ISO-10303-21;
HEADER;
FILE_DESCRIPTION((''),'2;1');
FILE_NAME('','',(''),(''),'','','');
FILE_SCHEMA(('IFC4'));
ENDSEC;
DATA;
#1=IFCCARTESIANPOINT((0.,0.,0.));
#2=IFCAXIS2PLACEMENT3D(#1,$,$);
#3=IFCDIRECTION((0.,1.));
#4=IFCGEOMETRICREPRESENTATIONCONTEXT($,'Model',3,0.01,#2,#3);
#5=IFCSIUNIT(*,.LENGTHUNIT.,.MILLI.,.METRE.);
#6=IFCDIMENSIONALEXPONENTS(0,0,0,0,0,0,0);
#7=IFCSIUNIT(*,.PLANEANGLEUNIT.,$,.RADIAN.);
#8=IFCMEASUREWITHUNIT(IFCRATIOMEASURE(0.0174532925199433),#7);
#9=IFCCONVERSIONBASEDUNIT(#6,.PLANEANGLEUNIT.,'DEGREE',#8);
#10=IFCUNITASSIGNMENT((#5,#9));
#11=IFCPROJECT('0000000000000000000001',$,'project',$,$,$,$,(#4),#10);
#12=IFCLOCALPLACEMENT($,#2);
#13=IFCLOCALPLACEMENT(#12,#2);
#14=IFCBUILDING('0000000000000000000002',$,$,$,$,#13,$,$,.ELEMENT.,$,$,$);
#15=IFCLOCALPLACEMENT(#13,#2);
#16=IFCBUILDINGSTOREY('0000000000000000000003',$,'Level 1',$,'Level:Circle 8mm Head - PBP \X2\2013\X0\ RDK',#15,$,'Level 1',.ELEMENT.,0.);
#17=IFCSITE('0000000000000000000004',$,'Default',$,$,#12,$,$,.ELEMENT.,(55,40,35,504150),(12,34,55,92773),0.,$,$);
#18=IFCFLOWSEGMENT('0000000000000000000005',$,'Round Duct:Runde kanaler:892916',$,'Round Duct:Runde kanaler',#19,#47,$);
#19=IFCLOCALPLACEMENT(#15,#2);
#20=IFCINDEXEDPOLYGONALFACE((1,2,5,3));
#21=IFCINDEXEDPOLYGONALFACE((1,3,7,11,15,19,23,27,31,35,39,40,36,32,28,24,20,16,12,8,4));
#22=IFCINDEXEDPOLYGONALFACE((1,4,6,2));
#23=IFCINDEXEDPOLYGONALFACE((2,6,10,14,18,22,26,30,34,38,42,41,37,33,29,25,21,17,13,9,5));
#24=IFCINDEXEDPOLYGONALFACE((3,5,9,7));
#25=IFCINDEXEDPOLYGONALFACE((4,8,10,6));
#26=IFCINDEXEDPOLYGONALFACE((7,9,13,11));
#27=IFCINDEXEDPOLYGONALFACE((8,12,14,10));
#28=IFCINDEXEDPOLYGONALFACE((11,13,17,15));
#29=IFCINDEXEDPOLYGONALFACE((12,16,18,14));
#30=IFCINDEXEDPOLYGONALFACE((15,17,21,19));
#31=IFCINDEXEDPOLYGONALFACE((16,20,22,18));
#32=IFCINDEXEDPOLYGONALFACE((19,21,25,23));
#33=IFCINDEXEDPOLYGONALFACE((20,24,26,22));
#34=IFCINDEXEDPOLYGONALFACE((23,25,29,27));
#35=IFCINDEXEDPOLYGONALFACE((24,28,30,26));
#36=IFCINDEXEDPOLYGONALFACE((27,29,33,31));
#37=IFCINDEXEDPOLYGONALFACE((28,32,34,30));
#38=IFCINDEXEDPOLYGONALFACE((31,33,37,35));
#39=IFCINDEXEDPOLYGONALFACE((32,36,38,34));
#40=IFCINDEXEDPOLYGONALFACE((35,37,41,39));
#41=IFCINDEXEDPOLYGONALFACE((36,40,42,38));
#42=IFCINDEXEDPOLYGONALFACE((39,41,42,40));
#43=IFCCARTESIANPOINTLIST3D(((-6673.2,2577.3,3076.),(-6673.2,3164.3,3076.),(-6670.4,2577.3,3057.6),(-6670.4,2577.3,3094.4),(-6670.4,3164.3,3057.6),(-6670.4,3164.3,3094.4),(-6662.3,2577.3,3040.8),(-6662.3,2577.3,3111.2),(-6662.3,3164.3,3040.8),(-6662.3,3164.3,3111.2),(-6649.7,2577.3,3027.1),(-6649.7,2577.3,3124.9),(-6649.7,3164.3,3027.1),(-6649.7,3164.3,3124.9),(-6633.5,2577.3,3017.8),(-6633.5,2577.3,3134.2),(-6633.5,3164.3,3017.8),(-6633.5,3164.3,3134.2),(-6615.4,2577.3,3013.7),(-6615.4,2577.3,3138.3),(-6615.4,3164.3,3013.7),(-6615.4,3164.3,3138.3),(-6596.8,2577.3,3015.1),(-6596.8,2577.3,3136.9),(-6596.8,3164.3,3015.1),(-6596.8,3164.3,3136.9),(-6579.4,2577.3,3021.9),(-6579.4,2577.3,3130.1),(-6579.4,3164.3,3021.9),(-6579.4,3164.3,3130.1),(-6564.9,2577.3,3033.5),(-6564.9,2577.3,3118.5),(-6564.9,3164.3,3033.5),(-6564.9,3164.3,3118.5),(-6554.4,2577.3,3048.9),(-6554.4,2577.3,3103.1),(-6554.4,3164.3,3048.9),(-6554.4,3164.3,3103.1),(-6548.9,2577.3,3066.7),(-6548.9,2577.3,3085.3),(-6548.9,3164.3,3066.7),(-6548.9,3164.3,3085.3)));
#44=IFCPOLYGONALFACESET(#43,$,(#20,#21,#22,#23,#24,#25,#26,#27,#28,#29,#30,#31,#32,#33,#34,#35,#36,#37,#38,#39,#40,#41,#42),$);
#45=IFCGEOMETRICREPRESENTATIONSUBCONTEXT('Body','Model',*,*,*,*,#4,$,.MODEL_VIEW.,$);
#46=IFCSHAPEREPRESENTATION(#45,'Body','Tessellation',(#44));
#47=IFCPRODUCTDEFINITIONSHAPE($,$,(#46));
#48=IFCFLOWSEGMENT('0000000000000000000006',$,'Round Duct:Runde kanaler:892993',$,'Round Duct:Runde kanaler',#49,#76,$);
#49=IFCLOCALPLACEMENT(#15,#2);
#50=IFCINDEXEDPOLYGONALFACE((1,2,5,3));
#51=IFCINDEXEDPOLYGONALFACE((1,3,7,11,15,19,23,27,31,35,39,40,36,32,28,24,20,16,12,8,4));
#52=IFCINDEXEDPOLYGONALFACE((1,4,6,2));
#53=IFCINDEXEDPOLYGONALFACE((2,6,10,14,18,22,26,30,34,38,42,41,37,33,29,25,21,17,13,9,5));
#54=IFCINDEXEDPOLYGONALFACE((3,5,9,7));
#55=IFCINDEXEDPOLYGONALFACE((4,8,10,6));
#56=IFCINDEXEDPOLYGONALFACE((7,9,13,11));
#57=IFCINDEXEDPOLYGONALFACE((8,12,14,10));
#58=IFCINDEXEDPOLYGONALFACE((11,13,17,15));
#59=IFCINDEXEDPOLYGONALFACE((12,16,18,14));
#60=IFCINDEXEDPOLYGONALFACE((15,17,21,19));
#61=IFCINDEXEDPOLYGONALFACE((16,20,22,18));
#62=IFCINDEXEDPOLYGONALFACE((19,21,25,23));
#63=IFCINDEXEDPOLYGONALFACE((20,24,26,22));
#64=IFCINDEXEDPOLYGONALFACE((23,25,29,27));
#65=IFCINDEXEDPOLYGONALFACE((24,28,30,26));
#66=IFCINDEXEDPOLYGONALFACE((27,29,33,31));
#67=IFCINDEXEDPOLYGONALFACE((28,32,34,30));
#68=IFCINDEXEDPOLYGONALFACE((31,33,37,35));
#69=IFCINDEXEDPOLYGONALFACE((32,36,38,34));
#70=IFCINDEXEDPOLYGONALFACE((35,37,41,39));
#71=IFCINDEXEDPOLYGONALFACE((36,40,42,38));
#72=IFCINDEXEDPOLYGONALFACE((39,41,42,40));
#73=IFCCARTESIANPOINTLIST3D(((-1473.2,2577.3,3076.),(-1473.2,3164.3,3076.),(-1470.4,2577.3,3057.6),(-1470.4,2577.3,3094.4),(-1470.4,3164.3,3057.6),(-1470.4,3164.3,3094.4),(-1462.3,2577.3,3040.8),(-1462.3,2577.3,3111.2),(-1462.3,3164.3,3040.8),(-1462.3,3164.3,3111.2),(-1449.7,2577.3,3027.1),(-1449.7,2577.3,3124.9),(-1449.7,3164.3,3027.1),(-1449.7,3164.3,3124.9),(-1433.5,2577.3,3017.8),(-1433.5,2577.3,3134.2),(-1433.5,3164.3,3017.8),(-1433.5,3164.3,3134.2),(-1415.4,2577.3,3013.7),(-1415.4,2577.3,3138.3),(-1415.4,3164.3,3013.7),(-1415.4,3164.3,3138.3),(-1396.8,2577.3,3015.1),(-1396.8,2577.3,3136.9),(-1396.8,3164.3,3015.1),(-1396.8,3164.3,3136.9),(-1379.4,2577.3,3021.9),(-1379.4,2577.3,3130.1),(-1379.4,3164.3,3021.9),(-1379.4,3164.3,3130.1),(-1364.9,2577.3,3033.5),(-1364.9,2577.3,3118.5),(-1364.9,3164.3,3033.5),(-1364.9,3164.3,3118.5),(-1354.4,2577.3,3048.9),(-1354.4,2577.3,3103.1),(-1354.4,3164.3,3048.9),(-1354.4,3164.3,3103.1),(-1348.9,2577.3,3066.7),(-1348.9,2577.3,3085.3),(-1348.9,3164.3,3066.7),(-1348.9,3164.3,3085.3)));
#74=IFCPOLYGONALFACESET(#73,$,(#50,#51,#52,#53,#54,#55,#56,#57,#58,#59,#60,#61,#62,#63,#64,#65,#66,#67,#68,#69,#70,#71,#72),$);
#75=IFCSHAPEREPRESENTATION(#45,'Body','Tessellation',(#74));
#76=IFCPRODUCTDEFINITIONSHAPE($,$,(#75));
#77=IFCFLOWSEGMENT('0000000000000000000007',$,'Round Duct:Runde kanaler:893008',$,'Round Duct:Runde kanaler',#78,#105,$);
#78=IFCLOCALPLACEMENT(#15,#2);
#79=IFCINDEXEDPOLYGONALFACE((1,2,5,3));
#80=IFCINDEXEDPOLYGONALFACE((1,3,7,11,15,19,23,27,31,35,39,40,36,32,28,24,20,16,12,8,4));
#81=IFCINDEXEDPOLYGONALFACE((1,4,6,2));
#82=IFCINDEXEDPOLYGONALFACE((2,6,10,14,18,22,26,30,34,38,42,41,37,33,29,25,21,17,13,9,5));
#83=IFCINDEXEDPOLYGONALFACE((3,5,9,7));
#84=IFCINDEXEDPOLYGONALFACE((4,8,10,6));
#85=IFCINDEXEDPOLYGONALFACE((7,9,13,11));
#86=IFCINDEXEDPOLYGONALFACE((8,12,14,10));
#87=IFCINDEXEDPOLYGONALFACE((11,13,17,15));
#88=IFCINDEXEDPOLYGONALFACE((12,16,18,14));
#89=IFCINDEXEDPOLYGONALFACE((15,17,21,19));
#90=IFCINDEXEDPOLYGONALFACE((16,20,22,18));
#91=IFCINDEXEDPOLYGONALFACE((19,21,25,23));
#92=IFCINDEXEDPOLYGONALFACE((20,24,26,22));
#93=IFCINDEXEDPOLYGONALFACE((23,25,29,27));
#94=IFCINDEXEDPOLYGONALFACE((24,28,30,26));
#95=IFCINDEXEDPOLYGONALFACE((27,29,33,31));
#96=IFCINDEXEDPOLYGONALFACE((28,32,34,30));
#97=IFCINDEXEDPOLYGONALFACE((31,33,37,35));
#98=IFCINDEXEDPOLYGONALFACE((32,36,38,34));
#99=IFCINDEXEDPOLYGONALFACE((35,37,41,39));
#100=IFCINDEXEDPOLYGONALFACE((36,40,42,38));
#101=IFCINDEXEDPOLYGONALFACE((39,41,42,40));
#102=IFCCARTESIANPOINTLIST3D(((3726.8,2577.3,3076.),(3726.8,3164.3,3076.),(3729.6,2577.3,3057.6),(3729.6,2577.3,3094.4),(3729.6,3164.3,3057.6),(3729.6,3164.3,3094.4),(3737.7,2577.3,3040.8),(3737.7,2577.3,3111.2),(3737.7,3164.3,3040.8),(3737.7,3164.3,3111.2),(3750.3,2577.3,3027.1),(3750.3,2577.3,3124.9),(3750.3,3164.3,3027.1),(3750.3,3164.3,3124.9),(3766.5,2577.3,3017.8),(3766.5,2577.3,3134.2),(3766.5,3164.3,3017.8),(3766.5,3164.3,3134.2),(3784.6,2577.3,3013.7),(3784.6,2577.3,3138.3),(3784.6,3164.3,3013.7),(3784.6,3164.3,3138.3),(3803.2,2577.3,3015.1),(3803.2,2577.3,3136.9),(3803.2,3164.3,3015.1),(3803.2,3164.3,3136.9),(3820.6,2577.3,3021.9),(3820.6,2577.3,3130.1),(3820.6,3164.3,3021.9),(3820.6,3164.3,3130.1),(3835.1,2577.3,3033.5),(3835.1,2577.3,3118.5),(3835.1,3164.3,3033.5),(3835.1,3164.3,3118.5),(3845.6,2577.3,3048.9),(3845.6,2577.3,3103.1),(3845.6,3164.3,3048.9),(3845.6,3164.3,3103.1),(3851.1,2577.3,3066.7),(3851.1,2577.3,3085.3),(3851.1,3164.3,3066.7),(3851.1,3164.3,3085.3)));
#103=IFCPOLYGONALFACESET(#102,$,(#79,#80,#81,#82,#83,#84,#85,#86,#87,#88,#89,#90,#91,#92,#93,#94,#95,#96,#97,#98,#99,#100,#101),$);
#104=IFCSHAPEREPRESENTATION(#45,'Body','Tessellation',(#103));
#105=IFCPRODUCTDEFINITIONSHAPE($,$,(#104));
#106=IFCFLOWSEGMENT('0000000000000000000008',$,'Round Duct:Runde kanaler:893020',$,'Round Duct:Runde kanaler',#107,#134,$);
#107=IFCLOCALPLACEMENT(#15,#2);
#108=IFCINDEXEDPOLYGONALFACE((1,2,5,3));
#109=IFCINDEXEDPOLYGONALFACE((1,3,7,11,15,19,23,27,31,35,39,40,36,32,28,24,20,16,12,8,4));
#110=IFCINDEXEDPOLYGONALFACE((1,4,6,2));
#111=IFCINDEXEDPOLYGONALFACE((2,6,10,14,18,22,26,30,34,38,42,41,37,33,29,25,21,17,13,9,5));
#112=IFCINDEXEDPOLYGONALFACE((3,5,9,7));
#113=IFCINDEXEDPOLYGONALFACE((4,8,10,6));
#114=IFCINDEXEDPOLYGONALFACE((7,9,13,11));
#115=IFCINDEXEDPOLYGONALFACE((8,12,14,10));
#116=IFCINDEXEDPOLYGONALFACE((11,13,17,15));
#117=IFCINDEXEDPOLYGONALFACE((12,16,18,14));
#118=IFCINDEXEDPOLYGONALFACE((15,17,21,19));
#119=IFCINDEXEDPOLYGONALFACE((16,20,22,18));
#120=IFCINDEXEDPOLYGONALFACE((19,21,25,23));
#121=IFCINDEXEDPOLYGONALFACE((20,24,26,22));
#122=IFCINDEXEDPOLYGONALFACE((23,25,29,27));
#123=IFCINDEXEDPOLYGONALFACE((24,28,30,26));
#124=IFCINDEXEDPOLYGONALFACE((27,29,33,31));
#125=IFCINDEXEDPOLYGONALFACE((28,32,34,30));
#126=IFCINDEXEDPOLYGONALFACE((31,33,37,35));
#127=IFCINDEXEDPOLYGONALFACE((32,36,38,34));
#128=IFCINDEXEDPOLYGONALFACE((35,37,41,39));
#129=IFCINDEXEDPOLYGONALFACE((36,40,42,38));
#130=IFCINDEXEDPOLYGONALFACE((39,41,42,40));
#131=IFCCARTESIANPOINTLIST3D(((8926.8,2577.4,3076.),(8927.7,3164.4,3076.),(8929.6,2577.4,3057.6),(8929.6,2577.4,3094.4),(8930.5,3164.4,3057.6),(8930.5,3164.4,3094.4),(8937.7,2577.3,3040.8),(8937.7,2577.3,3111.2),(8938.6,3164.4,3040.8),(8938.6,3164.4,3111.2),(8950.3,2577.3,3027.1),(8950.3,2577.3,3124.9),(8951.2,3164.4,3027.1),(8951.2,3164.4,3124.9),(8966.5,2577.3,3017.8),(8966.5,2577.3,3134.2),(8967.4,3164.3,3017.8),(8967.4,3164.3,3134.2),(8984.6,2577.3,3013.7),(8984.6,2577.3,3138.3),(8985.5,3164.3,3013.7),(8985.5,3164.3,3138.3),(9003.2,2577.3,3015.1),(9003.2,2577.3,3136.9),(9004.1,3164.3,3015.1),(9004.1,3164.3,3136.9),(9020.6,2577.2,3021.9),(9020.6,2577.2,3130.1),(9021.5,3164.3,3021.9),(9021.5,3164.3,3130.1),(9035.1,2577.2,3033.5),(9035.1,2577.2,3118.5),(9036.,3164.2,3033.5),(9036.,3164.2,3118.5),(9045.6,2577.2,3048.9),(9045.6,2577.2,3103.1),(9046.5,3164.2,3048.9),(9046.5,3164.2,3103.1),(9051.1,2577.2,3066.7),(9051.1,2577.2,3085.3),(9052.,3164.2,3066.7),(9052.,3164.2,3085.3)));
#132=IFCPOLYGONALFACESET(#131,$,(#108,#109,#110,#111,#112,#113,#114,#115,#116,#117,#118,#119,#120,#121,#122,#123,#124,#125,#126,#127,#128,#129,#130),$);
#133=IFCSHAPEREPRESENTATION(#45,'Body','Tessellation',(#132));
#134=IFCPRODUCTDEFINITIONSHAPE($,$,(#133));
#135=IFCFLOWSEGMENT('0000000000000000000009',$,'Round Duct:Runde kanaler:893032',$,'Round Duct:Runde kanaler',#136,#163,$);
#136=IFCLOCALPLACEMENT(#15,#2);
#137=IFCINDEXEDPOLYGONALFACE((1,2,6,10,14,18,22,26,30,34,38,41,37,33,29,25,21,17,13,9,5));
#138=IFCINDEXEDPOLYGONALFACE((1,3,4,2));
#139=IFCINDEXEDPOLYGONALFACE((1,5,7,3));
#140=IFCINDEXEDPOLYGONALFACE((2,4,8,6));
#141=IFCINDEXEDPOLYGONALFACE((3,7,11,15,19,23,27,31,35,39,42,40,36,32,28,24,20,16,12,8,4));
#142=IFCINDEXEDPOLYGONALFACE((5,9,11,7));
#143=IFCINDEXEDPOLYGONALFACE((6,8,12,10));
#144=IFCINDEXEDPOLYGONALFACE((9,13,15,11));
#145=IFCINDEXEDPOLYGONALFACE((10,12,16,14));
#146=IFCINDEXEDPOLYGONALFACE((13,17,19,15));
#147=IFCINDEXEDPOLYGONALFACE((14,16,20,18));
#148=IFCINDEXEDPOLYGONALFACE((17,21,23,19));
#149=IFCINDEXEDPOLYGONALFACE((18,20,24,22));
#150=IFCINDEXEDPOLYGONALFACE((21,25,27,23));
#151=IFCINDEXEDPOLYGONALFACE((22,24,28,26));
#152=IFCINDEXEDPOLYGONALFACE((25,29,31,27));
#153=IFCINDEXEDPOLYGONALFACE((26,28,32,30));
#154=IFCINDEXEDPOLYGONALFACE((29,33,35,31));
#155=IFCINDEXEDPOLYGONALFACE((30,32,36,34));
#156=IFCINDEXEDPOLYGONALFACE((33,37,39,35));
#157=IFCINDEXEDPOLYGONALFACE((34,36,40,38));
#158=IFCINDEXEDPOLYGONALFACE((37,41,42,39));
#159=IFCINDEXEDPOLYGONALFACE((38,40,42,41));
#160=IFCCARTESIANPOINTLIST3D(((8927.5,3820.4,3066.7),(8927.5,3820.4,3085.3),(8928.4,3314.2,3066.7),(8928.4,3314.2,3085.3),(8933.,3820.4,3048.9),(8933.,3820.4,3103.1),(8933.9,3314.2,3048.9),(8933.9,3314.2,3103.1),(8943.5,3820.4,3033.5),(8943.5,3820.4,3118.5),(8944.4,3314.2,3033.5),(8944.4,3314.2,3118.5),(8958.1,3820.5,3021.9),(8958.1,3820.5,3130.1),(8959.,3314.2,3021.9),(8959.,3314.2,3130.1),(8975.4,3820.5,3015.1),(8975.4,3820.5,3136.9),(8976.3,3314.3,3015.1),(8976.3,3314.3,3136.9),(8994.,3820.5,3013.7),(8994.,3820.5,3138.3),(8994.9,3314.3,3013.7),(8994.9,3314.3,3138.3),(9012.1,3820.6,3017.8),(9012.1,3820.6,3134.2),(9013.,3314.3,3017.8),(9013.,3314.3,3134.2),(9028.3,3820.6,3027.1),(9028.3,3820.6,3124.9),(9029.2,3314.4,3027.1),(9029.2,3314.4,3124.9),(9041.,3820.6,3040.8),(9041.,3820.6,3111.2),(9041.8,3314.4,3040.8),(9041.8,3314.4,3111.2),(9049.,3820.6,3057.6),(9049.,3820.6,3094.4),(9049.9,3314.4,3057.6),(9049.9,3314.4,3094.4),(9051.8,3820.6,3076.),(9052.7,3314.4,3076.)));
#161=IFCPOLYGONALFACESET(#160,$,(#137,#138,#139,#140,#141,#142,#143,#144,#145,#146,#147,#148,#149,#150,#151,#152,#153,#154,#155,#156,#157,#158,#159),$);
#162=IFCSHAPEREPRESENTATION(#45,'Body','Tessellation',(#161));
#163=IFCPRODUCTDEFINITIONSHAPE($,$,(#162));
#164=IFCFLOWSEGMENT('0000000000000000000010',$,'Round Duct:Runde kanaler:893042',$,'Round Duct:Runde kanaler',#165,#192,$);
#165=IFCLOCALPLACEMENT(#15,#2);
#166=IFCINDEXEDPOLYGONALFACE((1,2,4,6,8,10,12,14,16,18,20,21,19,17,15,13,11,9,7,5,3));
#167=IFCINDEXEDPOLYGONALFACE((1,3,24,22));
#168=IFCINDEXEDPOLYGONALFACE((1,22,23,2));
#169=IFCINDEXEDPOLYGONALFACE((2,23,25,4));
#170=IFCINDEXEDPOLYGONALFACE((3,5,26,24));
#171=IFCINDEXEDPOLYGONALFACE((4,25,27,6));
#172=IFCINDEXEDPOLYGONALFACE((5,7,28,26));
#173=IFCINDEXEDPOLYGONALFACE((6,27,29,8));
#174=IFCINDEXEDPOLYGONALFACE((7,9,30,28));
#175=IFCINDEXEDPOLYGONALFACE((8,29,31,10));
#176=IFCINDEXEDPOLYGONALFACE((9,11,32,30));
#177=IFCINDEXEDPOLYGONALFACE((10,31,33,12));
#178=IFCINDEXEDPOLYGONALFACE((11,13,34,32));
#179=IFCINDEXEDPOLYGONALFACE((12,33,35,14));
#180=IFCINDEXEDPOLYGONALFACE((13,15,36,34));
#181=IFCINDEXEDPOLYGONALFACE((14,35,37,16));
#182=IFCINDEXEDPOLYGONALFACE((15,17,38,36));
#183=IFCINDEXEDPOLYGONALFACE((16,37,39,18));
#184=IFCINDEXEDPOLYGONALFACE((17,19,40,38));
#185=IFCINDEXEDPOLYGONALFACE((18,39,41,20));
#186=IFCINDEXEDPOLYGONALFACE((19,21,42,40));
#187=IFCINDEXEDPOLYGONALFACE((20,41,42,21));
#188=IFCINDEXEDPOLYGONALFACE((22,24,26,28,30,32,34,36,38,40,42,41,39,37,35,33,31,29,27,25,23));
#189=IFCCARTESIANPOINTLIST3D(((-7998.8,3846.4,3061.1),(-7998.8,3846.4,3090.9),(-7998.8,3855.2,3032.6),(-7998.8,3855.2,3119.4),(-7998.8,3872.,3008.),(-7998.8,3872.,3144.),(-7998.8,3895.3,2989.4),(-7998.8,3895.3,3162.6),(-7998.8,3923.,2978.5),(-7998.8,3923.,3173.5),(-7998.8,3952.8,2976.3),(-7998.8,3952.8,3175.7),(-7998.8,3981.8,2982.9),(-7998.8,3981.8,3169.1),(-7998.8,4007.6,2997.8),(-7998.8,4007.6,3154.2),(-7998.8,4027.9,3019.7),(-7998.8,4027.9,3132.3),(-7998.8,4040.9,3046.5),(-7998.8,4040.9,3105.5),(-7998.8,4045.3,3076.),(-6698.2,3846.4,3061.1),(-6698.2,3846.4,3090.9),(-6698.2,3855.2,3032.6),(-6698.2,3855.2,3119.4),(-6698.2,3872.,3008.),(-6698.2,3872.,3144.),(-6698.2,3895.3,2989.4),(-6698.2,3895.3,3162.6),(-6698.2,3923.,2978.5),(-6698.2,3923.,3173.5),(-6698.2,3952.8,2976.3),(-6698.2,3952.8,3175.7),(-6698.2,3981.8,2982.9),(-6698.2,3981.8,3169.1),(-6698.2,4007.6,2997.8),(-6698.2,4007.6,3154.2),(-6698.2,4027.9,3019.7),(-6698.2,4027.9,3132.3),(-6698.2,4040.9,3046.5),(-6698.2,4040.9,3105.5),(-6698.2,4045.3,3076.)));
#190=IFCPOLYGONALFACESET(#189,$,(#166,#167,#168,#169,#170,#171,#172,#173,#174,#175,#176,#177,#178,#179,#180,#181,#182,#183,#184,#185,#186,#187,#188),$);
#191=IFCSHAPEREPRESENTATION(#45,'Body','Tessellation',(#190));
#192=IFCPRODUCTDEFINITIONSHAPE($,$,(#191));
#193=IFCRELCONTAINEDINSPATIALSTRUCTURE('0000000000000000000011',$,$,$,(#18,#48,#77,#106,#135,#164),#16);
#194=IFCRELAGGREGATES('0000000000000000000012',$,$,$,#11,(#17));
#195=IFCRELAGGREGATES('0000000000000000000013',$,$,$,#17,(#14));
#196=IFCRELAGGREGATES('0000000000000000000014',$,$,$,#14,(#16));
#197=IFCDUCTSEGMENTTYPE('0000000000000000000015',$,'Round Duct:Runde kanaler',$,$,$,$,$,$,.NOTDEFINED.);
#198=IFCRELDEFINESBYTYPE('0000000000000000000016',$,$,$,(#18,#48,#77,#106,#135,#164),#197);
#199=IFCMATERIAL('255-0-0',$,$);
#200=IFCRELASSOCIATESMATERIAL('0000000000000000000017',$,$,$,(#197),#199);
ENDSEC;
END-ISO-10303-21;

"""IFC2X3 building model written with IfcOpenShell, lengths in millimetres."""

from ifc_helpers import new_model, entity, si_unit, converted_unit, direction, frame, frame_2d, origin, origin_2d_with_axis, place, context, subcontext, project, spatial, circle, extrude, material, type_object, element, save


model = new_model("IFC2X3")

# Units and contexts
model_context = context("Model", 3, precision=0.01, world=origin(), true_north=direction((0.0, 1.0)))
body_context = subcontext(model_context, "Body", "Model", "MODEL_VIEW")
ifc_project = project(units=[si_unit("LENGTHUNIT", "METRE", prefix="MILLI"), converted_unit("PLANEANGLEUNIT", "DEGREE", entity("IfcRatioMeasure", 0.0174532925199433), si_unit("PLANEANGLEUNIT", "RADIAN"), dimensions=[0, 0, 0, 0, 0, 0, 0])], contexts=[model_context])

# Site, building, storey
site_placement = place(None, origin())
site = spatial("IfcSite", under=ifc_project, at=site_placement, Name="Default", CompositionType="ELEMENT", RefLatitude=(55, 40, 35, 504150), RefLongitude=(12, 34, 55, 92773), RefElevation=0.0)
building_placement = place(site_placement, origin())
building = spatial("IfcBuilding", under=site, at=building_placement, CompositionType="ELEMENT")
storey_placement = place(building_placement, origin())
storey = spatial("IfcBuildingStorey", under=building, at=storey_placement, Name="Level 1", ObjectType="Level:Circle 8mm Head - PBP – RDK", LongName="Level 1", CompositionType="ELEMENT", Elevation=0.0)

# Flow segments
ifc_material_1 = material(Name="255-0-0")
duct_segment_type = type_object("IfcDuctSegmentType", Name="Round Duct:Runde kanaler", PredefinedType="NOTDEFINED", material=ifc_material_1)
flow_segment_1_placement = place(storey_placement, origin())
element("IfcFlowSegment", 1, at=flow_segment_1_placement, inside=storey, type_object=duct_segment_type, Name="Round Duct:Runde kanaler:892916", ObjectType="Round Duct:Runde kanaler", context=body_context, shape_type="SweptSolid", body=[
    extrude(circle(Radius=62.5, at=origin_2d_with_axis()), frame((-6610.7, 2577.3, 3076.0), z_axis=(0.0, 1.0, 0.0), x_axis=(-1.0, 0.0, 0.0)), (0.0, 0.0, 1.0), 587.0),
])
flow_segment_2_placement = place(storey_placement, origin())
element("IfcFlowSegment", 2, at=flow_segment_2_placement, inside=storey, type_object=duct_segment_type, Name="Round Duct:Runde kanaler:892993", ObjectType="Round Duct:Runde kanaler", context=body_context, shape_type="SweptSolid", body=[
    extrude(circle(Radius=62.5, at=origin_2d_with_axis()), frame((-1410.7, 2577.3, 3076.0), z_axis=(0.0, 1.0, 0.0), x_axis=(-1.0, 0.0, 0.0)), (0.0, 0.0, 1.0), 587.0),
])
flow_segment_3_placement = place(storey_placement, origin())
element("IfcFlowSegment", 3, at=flow_segment_3_placement, inside=storey, type_object=duct_segment_type, Name="Round Duct:Runde kanaler:893008", ObjectType="Round Duct:Runde kanaler", context=body_context, shape_type="SweptSolid", body=[
    extrude(circle(Radius=62.5, at=origin_2d_with_axis()), frame((3789.3, 2577.3, 3076.0), z_axis=(0.0, 1.0, 0.0), x_axis=(-1.0, 0.0, 0.0)), (0.0, 0.0, 1.0), 587.0),
])
flow_segment_4_placement = place(storey_placement, origin())
element("IfcFlowSegment", 4, at=flow_segment_4_placement, inside=storey, type_object=duct_segment_type, Name="Round Duct:Runde kanaler:893020", ObjectType="Round Duct:Runde kanaler", context=body_context, shape_type="SweptSolid", body=[
    extrude(circle(Radius=62.5, at=frame_2d((0.0, 0.0), x_axis=(1.0, 0.0))), frame((8989.3, 2577.3, 3076.0), z_axis=(0.001512, 0.999999, 0.0), x_axis=(-0.999999, 0.001512, 0.0)), (0.0, 0.0, 1.0), 587.0),
])
flow_segment_5_placement = place(storey_placement, origin())
element("IfcFlowSegment", 5, at=flow_segment_5_placement, inside=storey, type_object=duct_segment_type, Name="Round Duct:Runde kanaler:893032", ObjectType="Round Duct:Runde kanaler", context=body_context, shape_type="SweptSolid", body=[
    extrude(circle(Radius=62.5, at=origin_2d_with_axis()), frame((8989.3, 3820.5, 3076.0), z_axis=(0.001754, -0.999998, 0.0), x_axis=(0.999998, 0.001754, 0.0)), (0.0, 0.0, 1.0), 506.2),
])
flow_segment_6_placement = place(storey_placement, origin())
element("IfcFlowSegment", 6, at=flow_segment_6_placement, inside=storey, type_object=duct_segment_type, Name="Round Duct:Runde kanaler:893042", ObjectType="Round Duct:Runde kanaler", context=body_context, shape_type="SweptSolid", body=[
    extrude(circle(Radius=100.0, at=origin_2d_with_axis()), frame((-7998.8, 3945.3, 3076.0), z_axis=(1.0, 0.0, 0.0), x_axis=(0.0, 1.0, 0.0)), (0.0, 0.0, 1.0), 1300.6),
])

save(model, "model.ifc")
